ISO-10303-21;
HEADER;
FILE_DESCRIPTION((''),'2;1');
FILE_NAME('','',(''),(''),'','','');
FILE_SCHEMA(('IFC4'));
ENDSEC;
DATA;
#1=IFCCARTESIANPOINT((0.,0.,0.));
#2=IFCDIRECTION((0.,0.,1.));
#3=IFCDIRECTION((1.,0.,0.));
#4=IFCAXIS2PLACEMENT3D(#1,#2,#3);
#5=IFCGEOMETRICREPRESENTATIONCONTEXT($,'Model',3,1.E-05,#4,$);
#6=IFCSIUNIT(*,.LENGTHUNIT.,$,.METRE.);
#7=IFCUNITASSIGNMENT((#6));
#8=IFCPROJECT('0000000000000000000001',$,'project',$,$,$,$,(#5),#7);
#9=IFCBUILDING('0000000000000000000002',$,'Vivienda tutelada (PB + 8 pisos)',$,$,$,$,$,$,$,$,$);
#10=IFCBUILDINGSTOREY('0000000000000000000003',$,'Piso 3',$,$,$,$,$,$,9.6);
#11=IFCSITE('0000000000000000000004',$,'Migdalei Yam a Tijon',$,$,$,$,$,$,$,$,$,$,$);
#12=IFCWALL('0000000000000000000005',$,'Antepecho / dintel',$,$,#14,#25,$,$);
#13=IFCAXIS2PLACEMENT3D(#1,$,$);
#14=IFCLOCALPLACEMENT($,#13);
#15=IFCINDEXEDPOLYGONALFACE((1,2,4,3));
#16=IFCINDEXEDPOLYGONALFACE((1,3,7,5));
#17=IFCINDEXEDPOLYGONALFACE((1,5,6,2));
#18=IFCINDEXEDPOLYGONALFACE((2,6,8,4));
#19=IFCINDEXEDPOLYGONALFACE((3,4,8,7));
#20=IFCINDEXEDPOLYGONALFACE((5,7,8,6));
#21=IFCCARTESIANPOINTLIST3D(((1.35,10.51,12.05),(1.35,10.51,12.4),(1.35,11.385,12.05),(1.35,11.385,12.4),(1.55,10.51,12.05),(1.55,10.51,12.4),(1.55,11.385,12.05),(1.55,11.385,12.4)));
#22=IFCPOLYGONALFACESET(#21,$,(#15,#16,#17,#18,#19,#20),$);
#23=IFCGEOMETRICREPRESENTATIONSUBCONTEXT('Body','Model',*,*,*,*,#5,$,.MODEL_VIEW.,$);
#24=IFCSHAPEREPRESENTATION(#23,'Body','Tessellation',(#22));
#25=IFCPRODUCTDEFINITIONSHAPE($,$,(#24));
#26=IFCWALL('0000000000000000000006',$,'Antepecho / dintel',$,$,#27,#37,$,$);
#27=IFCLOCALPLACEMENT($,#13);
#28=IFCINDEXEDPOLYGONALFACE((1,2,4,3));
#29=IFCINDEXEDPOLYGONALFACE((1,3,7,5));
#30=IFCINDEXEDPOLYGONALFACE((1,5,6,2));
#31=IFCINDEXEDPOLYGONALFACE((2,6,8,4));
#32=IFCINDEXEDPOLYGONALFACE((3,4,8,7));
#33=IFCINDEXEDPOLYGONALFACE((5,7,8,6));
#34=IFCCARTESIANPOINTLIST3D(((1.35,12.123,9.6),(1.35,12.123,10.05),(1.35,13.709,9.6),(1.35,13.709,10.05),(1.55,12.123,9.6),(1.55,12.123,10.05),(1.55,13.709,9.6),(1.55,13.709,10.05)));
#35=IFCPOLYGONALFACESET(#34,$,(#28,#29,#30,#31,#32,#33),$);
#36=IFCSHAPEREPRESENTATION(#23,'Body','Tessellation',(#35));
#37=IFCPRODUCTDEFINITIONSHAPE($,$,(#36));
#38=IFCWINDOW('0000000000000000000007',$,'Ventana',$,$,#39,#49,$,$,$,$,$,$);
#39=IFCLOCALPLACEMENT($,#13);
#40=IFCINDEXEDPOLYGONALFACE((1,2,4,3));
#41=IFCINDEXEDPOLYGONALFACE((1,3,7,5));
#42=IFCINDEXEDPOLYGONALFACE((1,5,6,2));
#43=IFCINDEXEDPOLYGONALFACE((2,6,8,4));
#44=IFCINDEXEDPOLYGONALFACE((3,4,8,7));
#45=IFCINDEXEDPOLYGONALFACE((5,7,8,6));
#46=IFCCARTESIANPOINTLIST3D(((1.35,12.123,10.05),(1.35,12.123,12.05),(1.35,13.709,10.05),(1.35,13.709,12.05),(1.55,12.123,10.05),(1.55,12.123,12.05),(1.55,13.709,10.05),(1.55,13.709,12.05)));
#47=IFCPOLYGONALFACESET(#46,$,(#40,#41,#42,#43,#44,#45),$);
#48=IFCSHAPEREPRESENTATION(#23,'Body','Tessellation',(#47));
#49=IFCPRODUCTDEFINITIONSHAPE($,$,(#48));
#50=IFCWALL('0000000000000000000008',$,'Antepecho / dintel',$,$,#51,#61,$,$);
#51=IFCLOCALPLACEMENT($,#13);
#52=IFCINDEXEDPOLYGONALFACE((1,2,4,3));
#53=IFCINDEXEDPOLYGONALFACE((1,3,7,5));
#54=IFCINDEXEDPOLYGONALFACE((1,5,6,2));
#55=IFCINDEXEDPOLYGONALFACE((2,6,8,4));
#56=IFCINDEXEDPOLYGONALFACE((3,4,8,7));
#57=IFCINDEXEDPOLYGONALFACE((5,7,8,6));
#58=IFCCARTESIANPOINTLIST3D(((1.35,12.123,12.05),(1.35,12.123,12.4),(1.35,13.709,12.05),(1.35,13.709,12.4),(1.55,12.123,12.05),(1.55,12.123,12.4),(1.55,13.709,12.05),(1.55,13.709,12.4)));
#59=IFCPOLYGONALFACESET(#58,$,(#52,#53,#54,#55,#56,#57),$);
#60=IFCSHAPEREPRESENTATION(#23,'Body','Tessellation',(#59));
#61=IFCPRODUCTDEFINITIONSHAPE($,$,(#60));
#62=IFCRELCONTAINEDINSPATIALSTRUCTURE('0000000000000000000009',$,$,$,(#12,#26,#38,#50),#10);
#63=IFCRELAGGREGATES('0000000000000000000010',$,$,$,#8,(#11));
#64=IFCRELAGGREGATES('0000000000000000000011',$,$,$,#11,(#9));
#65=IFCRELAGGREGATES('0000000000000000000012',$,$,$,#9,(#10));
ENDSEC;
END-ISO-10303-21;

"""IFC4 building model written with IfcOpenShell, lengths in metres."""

from ifc_helpers import new_model, si_unit, frame, origin_with_axes, context, subcontext, project, spatial, line, indexed_curve, outline, extrude, element, save


model = new_model("IFC4")

# Units and contexts
model_context = context("Model", 3, precision=1e-05, world=origin_with_axes())
body_context = subcontext(model_context, "Body", "Model", "MODEL_VIEW")
ifc_project = project(units=[si_unit("LENGTHUNIT", "METRE")], contexts=[model_context])

# Site, building, storey
site = spatial("IfcSite", under=ifc_project, Name="Migdalei Yam a Tijon")
building = spatial("IfcBuilding", under=site, Name="Vivienda tutelada (PB + 8 pisos)")
storey = spatial("IfcBuildingStorey", under=building, Name="Piso 3", Elevation=9.6)

# Walls
element("IfcWall", 1, inside=storey, Name="Antepecho / dintel", context=body_context, shape_type="SweptSolid", body=[
    extrude(outline(indexed_curve([(0.0, 0.0), (0.2, 0.0), (0.2, 0.875), (0.0, 0.875)], segments=[line(1, 2, 3, 4, 1)])), frame((1.35, 10.51, 12.05), z_axis=(0.0, 0.0, 1.0), x_axis=(1.0, 0.0, 0.0)), (0.0, 0.0, 1.0), 0.35),
])
element("IfcWall", 2, inside=storey, Name="Antepecho / dintel", context=body_context, shape_type="SweptSolid", body=[
    extrude(outline(indexed_curve([(0.0, 0.0), (0.2, 0.0), (0.2, 1.586), (0.0, 1.586)], segments=[line(1, 2, 3, 4, 1)])), frame((1.35, 12.123, 9.6), z_axis=(0.0, 0.0, 1.0), x_axis=(1.0, 0.0, 0.0)), (0.0, 0.0, 1.0), 0.45),
])

# Window
element("IfcWindow", 3, inside=storey, Name="Ventana", context=body_context, shape_type="SweptSolid", body=[
    extrude(outline(indexed_curve([(0.0, 0.0), (0.2, 0.0), (0.2, 1.586), (0.0, 1.586)], segments=[line(1, 2, 3, 4, 1)])), frame((1.35, 12.123, 10.05), z_axis=(0.0, 0.0, 1.0), x_axis=(1.0, 0.0, 0.0)), (0.0, 0.0, 1.0), 2.0),
])

# Wall
element("IfcWall", 4, inside=storey, Name="Antepecho / dintel", context=body_context, shape_type="SweptSolid", body=[
    extrude(outline(indexed_curve([(0.0, 0.0), (0.2, 0.0), (0.2, 1.586), (0.0, 1.586)], segments=[line(1, 2, 3, 4, 1)])), frame((1.35, 12.123, 12.05), z_axis=(0.0, 0.0, 1.0), x_axis=(1.0, 0.0, 0.0)), (0.0, 0.0, 1.0), 0.35),
])

save(model, "model.ifc")
